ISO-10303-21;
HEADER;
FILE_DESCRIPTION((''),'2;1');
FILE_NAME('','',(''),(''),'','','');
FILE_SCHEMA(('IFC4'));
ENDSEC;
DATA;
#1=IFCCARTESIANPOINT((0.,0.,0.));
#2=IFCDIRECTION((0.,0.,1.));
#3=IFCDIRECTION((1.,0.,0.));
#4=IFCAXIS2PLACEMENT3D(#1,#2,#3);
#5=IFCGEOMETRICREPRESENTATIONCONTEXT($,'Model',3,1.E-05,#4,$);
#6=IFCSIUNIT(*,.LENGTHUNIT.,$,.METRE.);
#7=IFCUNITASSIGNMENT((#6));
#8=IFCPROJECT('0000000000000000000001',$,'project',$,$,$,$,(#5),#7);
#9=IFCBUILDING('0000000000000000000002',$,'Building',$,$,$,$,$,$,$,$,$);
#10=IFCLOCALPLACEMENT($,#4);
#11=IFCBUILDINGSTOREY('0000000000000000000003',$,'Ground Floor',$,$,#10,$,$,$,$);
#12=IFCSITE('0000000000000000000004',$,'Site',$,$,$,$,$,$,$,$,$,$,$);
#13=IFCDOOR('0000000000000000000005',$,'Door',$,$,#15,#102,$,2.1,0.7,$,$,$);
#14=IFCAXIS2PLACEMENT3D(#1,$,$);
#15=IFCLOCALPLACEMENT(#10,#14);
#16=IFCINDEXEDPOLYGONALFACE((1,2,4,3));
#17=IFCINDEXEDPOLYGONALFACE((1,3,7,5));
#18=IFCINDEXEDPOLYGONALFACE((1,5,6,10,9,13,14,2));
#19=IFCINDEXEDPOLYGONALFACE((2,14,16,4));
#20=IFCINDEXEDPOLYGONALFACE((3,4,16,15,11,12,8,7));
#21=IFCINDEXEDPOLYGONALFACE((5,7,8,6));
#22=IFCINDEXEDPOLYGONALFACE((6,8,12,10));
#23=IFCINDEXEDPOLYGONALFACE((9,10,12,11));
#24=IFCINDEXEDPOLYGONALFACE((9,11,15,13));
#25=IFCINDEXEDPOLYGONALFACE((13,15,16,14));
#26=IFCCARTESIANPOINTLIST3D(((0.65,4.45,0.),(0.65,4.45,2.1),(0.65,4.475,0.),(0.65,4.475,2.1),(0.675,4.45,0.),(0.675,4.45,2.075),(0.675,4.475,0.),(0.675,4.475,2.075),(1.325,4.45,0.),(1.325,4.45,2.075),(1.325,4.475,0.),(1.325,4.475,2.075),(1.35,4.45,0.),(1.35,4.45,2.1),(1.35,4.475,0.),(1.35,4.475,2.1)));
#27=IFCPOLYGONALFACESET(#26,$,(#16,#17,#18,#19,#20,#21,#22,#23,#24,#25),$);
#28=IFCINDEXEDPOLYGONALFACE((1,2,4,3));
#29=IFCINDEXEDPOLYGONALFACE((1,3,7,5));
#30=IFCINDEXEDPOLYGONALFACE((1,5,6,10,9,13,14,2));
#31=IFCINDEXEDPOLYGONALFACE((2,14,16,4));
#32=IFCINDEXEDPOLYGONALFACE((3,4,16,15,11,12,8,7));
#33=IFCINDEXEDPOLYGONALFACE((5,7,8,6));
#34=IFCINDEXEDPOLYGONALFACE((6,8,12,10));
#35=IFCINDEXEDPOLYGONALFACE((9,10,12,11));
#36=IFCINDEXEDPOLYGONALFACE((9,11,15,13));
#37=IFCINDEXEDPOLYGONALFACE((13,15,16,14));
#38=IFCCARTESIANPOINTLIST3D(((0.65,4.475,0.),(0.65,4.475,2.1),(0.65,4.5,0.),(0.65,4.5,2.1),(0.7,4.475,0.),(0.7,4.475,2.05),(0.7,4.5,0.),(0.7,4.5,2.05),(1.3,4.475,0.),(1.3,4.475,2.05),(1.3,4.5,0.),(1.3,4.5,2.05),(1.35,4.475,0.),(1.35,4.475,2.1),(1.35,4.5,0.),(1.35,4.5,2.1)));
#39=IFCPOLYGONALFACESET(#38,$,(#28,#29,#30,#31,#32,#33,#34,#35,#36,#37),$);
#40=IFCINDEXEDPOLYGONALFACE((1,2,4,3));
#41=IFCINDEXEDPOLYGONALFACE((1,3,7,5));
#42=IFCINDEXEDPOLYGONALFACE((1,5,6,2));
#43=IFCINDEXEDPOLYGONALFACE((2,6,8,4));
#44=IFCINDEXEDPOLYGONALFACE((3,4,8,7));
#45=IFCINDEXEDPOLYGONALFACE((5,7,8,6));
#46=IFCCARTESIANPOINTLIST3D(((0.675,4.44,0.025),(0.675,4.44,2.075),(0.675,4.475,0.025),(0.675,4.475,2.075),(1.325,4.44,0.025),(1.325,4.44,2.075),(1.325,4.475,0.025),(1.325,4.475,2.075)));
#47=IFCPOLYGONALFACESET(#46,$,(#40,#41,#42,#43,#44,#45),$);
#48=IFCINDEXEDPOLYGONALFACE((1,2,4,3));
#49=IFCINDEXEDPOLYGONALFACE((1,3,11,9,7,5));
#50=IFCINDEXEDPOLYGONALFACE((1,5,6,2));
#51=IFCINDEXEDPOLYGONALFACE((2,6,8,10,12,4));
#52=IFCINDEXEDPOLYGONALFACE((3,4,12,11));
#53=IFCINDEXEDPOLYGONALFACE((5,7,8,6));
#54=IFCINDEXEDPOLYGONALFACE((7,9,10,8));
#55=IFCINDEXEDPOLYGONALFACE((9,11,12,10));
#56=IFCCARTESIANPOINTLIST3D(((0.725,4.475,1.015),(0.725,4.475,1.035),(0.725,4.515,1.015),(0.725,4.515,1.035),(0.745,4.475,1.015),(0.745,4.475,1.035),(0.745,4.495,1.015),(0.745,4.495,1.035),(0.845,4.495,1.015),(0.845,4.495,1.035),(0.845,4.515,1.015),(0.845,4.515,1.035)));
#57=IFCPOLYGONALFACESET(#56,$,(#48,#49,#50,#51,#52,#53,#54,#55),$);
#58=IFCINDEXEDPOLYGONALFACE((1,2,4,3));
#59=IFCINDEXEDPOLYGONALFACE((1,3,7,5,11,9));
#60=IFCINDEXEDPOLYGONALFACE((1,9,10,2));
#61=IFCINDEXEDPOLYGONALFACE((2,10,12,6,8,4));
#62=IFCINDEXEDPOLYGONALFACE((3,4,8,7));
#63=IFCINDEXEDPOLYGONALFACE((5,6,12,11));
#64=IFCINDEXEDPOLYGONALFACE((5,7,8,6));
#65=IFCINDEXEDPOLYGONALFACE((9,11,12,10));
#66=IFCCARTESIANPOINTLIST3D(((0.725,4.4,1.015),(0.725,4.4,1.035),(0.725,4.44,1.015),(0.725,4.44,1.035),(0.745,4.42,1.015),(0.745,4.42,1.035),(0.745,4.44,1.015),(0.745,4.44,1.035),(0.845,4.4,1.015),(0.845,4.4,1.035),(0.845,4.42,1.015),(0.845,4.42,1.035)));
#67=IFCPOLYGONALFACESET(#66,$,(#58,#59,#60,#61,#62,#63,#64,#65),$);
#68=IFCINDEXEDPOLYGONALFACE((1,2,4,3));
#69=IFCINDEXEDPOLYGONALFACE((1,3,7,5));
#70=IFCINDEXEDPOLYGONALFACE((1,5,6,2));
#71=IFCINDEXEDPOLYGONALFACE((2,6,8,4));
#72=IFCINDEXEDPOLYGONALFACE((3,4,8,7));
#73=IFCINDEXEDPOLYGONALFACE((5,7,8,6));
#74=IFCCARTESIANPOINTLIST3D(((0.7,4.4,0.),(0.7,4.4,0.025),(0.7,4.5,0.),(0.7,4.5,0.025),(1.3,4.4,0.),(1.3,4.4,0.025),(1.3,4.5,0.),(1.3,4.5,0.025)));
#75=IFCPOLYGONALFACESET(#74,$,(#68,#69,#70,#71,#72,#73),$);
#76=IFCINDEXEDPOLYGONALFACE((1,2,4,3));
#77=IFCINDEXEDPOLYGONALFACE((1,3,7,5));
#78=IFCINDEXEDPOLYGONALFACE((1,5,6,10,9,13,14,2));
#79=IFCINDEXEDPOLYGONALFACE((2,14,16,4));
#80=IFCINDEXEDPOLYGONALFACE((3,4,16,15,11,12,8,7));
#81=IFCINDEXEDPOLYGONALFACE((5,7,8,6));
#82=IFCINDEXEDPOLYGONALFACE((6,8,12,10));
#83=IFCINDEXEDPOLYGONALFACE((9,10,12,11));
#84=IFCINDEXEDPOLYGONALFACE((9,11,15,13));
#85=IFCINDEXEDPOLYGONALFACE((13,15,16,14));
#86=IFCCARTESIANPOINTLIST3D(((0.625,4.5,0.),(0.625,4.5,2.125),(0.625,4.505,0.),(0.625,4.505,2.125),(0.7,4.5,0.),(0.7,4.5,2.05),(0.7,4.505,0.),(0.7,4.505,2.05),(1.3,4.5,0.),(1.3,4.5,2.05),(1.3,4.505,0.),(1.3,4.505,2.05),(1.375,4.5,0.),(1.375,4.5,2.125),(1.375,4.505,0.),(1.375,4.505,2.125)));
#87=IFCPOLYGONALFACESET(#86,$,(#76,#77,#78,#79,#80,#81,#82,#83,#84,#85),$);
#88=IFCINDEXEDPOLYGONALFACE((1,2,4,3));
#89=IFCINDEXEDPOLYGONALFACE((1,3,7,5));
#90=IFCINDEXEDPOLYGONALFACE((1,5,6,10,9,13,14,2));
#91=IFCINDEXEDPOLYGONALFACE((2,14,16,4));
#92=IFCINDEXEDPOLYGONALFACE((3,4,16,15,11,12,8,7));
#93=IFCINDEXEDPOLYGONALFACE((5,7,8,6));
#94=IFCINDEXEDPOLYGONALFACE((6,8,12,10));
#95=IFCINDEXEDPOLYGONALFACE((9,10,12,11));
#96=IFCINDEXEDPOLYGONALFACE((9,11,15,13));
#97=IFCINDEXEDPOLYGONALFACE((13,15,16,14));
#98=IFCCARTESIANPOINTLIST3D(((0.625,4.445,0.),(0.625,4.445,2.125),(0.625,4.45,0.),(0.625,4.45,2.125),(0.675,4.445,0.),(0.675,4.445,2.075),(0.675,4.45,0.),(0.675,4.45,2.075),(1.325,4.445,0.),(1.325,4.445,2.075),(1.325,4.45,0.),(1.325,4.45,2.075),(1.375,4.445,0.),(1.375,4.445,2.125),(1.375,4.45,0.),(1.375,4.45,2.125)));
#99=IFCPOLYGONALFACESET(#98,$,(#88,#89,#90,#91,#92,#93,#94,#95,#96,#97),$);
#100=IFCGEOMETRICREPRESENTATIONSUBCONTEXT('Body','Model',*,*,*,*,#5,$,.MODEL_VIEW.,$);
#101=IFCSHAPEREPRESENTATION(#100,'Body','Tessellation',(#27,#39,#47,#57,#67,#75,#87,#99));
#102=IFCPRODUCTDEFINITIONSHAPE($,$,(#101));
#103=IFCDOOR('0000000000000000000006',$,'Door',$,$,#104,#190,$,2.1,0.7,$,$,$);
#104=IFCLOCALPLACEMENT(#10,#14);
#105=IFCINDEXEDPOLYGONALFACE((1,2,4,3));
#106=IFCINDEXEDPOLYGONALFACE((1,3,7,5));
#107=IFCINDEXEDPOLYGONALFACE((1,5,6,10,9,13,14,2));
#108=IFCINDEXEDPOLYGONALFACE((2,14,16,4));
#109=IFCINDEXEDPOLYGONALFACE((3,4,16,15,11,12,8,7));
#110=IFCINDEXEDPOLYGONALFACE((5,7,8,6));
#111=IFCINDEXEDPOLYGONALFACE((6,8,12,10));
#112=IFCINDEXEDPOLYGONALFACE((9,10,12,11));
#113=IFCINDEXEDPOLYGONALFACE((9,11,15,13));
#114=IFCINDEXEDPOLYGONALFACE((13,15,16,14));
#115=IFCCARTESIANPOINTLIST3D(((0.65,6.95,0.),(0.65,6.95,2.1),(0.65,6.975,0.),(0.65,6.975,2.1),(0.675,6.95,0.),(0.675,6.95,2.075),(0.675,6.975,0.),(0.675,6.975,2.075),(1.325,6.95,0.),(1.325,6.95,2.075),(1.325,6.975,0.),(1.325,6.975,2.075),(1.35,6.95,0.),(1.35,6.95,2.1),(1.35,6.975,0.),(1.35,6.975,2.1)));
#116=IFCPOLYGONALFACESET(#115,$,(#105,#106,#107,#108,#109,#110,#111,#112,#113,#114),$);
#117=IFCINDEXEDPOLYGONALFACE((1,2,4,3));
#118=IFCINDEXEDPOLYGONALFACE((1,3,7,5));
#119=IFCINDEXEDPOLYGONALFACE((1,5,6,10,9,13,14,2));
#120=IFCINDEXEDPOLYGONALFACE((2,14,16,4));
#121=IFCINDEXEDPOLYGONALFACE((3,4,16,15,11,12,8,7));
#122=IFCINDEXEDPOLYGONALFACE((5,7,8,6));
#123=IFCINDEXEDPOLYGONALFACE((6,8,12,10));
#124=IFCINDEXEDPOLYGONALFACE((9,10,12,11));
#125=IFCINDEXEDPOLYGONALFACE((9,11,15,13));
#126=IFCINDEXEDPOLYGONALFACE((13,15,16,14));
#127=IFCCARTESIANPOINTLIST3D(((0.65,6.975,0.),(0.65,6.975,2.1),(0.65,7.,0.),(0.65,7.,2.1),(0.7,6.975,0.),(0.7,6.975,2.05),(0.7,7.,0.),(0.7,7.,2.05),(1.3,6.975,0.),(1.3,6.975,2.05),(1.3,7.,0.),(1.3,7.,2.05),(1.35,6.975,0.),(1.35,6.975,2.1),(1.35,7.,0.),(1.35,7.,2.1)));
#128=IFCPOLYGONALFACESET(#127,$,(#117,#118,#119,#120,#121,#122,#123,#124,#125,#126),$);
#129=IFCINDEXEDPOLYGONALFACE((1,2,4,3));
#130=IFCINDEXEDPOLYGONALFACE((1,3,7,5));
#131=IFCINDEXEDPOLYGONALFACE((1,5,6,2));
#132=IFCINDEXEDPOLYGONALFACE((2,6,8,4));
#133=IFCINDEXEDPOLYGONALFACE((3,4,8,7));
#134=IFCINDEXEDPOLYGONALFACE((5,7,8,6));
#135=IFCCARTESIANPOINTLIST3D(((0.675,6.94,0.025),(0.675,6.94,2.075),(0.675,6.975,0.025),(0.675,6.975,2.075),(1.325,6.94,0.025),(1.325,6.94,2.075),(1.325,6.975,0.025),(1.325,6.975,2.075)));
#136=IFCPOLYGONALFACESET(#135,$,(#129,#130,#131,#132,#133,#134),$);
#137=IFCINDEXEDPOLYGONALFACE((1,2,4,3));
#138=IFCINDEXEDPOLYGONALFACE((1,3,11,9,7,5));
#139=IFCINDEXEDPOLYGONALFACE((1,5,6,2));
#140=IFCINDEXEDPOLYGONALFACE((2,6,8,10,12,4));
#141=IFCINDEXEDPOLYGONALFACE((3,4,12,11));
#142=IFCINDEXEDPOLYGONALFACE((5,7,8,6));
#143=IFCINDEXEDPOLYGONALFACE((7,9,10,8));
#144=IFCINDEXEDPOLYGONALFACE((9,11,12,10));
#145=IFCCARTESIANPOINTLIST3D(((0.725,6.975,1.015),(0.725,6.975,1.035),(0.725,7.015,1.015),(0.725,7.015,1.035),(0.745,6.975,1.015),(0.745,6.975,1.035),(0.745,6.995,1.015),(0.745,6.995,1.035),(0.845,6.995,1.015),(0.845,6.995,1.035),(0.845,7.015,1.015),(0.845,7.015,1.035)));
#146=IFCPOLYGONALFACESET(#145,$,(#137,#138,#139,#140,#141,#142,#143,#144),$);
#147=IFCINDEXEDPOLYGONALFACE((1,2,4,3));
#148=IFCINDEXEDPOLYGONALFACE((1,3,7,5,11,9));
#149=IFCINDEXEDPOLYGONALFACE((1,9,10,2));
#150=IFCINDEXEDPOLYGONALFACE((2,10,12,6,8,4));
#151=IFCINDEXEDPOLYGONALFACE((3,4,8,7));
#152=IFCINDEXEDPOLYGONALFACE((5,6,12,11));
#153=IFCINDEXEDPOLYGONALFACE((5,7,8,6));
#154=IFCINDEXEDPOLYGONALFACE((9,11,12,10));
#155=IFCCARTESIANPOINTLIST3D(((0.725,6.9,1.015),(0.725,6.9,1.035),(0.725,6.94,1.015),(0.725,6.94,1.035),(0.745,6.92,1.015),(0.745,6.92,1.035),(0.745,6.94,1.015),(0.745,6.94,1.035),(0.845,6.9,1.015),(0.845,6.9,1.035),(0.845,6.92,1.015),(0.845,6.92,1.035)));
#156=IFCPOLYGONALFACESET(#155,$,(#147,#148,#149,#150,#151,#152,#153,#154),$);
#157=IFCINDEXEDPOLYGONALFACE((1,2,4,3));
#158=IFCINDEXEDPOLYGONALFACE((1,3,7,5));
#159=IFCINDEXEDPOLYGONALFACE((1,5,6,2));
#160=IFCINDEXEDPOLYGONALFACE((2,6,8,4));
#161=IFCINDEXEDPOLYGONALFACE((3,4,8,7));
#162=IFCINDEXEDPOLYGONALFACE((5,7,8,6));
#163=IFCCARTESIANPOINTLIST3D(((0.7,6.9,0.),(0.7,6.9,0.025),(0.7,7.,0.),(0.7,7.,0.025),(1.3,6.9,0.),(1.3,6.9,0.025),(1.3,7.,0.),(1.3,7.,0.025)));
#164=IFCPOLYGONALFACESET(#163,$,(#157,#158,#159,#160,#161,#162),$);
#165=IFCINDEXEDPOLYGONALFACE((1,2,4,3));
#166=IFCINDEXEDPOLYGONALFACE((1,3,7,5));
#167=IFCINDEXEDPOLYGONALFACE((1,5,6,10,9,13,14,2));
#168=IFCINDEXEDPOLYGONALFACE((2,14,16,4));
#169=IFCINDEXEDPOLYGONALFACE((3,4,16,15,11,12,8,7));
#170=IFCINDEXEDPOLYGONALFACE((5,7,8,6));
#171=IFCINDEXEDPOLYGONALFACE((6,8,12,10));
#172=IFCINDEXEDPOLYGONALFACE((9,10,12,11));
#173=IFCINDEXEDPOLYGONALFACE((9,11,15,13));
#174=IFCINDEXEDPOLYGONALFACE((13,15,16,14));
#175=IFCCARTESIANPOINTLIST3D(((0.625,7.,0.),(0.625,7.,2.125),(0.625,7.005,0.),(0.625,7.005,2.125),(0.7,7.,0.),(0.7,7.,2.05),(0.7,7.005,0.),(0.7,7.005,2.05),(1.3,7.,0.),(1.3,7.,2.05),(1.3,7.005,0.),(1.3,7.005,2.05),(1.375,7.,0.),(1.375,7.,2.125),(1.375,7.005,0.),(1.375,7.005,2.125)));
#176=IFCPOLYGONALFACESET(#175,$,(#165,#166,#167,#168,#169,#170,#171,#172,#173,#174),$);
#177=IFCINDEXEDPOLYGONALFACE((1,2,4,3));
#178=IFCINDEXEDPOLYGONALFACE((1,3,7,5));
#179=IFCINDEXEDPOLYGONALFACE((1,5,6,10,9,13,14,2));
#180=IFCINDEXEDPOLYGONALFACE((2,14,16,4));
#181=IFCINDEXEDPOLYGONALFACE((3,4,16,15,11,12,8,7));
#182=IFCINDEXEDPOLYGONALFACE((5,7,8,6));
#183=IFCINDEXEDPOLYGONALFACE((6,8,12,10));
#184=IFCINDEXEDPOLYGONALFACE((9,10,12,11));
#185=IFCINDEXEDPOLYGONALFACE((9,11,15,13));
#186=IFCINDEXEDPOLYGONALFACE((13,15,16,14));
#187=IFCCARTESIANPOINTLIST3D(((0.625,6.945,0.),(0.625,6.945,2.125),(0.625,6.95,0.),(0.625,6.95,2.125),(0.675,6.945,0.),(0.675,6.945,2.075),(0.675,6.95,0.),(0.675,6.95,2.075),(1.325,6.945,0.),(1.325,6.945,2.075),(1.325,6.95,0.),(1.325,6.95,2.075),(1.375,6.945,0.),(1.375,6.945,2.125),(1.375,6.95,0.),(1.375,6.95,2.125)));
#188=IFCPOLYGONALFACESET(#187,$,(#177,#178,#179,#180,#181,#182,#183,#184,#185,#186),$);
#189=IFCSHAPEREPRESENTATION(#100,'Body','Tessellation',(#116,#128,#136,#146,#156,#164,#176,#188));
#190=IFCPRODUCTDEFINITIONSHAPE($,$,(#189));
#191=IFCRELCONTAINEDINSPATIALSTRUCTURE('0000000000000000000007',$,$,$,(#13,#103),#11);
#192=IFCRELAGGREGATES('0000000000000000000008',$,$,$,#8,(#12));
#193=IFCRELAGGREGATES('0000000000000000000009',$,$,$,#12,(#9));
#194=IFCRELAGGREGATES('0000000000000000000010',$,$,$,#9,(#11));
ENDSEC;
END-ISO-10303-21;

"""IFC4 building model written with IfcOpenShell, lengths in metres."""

from ifc_helpers import new_model, si_unit, frame, origin_with_axes, place, context, subcontext, project, spatial, line, indexed_curve, outline, extrude, element, save


model = new_model("IFC4")

# Units and contexts
model_context = context("Model", 3, precision=1e-05, world=origin_with_axes())
body_context = subcontext(model_context, "Body", "Model", "MODEL_VIEW")
ifc_project = project(units=[si_unit("LENGTHUNIT", "METRE")], contexts=[model_context])

# Site, building, storey
site = spatial("IfcSite", under=ifc_project, Name="Site")
building = spatial("IfcBuilding", under=site, Name="Building")
storey_placement = place(None, origin_with_axes())
storey = spatial("IfcBuildingStorey", under=building, at=storey_placement, Name="Ground Floor")

# Doors
door_1_placement = place(storey_placement, frame((1.35, 4.5, 0.0), z_axis=(0.0, 0.0, 1.0), x_axis=(-1.0, 0.0, 0.0)))
element("IfcDoor", 1, at=door_1_placement, inside=storey, Name="Door", OverallHeight=2.1, OverallWidth=0.7, context=body_context, shape_type="SweptSolid", body=[
    extrude(outline(indexed_curve([(0.0, 0.0), (0.0, 2.1), (0.7, 2.1), (0.7, 0.0), (0.675, 0.0), (0.675, 2.075), (0.025, 2.075), (0.025, 0.0)], segments=[line(1, 2, 3, 4, 5, 6, 7, 8, 1)])), frame((0.0, 0.025, 0.0), z_axis=(0.0, -1.0, 0.0), x_axis=(1.0, 0.0, 0.0)), (0.0, 0.0, -1.0), 0.025),
    extrude(outline(indexed_curve([(0.0, 0.0), (0.0, 2.1), (0.7, 2.1), (0.7, 0.0), (0.65, 0.0), (0.65, 2.05), (0.05, 2.05), (0.05, 0.0)], segments=[line(1, 2, 3, 4, 5, 6, 7, 8, 1)])), frame((0.0, 0.0, 0.0), z_axis=(0.0, -1.0, 0.0), x_axis=(1.0, 0.0, 0.0)), (0.0, 0.0, -1.0), 0.025),
    extrude(outline(indexed_curve([(0.0, 0.0), (0.65, 0.0), (0.65, 0.035), (0.0, 0.035)], segments=[line(1, 2, 3, 4, 1)])), frame((0.025, 0.025, 0.025), z_axis=(0.0, 0.0, 1.0), x_axis=(1.0, 0.0, 0.0)), (0.0, 0.0, 1.0), 2.05),
    extrude(outline(indexed_curve([(0.0, 0.0), (0.0, -0.04), (-0.12, -0.04), (-0.12, -0.02), (-0.02, -0.02), (-0.02, 0.0)], segments=[line(1, 2, 3, 4, 5, 6, 1)])), frame((0.625, 0.025, 1.015), z_axis=(0.0, 0.0, 1.0), x_axis=(1.0, 0.0, 0.0)), (0.0, 0.0, 1.0), 0.02),
    extrude(outline(indexed_curve([(0.0, 0.0), (0.0, 0.04), (-0.12, 0.04), (-0.12, 0.02), (-0.02, 0.02), (-0.02, 0.0)], segments=[line(1, 2, 3, 4, 5, 6, 1)])), frame((0.625, 0.06, 1.015), z_axis=(0.0, 0.0, 1.0), x_axis=(1.0, 0.0, 0.0)), (0.0, 0.0, 1.0), 0.02),
    extrude(outline(indexed_curve([(0.0, 0.0), (0.6, 0.0), (0.6, 0.1), (0.0, 0.1)], segments=[line(1, 2, 3, 4, 1)])), frame((0.05, 0.0, 0.0), z_axis=(0.0, 0.0, 1.0), x_axis=(1.0, 0.0, 0.0)), (0.0, 0.0, 1.0), 0.025),
    extrude(outline(indexed_curve([(0.0, 0.0), (0.0, 2.125), (0.75, 2.125), (0.75, 0.0), (0.675, 0.0), (0.675, 2.05), (0.075, 2.05), (0.075, 0.0)], segments=[line(1, 2, 3, 4, 5, 6, 7, 8, 1)])), frame((-0.025, -0.005, 0.0), z_axis=(0.0, -1.0, 0.0), x_axis=(1.0, 0.0, 0.0)), (0.0, 0.0, -1.0), 0.005),
    extrude(outline(indexed_curve([(0.0, 0.0), (0.0, 2.125), (0.75, 2.125), (0.75, 0.0), (0.7, 0.0), (0.7, 2.075), (0.05, 2.075), (0.05, 0.0)], segments=[line(1, 2, 3, 4, 5, 6, 7, 8, 1)])), frame((-0.025, 0.05, 0.0), z_axis=(0.0, -1.0, 0.0), x_axis=(1.0, 0.0, 0.0)), (0.0, 0.0, -1.0), 0.005),
])
door_2_placement = place(storey_placement, frame((1.35, 7.0, 0.0), z_axis=(0.0, 0.0, 1.0), x_axis=(-1.0, 0.0, 0.0)))
element("IfcDoor", 2, at=door_2_placement, inside=storey, Name="Door", OverallHeight=2.1, OverallWidth=0.7, context=body_context, shape_type="SweptSolid", body=[
    extrude(outline(indexed_curve([(0.0, 0.0), (0.0, 2.1), (0.7, 2.1), (0.7, 0.0), (0.675, 0.0), (0.675, 2.075), (0.025, 2.075), (0.025, 0.0)], segments=[line(1, 2, 3, 4, 5, 6, 7, 8, 1)])), frame((0.0, 0.025, 0.0), z_axis=(0.0, -1.0, 0.0), x_axis=(1.0, 0.0, 0.0)), (0.0, 0.0, -1.0), 0.025),
    extrude(outline(indexed_curve([(0.0, 0.0), (0.0, 2.1), (0.7, 2.1), (0.7, 0.0), (0.65, 0.0), (0.65, 2.05), (0.05, 2.05), (0.05, 0.0)], segments=[line(1, 2, 3, 4, 5, 6, 7, 8, 1)])), frame((0.0, 0.0, 0.0), z_axis=(0.0, -1.0, 0.0), x_axis=(1.0, 0.0, 0.0)), (0.0, 0.0, -1.0), 0.025),
    extrude(outline(indexed_curve([(0.0, 0.0), (0.65, 0.0), (0.65, 0.035), (0.0, 0.035)], segments=[line(1, 2, 3, 4, 1)])), frame((0.025, 0.025, 0.025), z_axis=(0.0, 0.0, 1.0), x_axis=(1.0, 0.0, 0.0)), (0.0, 0.0, 1.0), 2.05),
    extrude(outline(indexed_curve([(0.0, 0.0), (0.0, -0.04), (-0.12, -0.04), (-0.12, -0.02), (-0.02, -0.02), (-0.02, 0.0)], segments=[line(1, 2, 3, 4, 5, 6, 1)])), frame((0.625, 0.025, 1.015), z_axis=(0.0, 0.0, 1.0), x_axis=(1.0, 0.0, 0.0)), (0.0, 0.0, 1.0), 0.02),
    extrude(outline(indexed_curve([(0.0, 0.0), (0.0, 0.04), (-0.12, 0.04), (-0.12, 0.02), (-0.02, 0.02), (-0.02, 0.0)], segments=[line(1, 2, 3, 4, 5, 6, 1)])), frame((0.625, 0.06, 1.015), z_axis=(0.0, 0.0, 1.0), x_axis=(1.0, 0.0, 0.0)), (0.0, 0.0, 1.0), 0.02),
    extrude(outline(indexed_curve([(0.0, 0.0), (0.6, 0.0), (0.6, 0.1), (0.0, 0.1)], segments=[line(1, 2, 3, 4, 1)])), frame((0.05, 0.0, 0.0), z_axis=(0.0, 0.0, 1.0), x_axis=(1.0, 0.0, 0.0)), (0.0, 0.0, 1.0), 0.025),
    extrude(outline(indexed_curve([(0.0, 0.0), (0.0, 2.125), (0.75, 2.125), (0.75, 0.0), (0.675, 0.0), (0.675, 2.05), (0.075, 2.05), (0.075, 0.0)], segments=[line(1, 2, 3, 4, 5, 6, 7, 8, 1)])), frame((-0.025, -0.005, 0.0), z_axis=(0.0, -1.0, 0.0), x_axis=(1.0, 0.0, 0.0)), (0.0, 0.0, -1.0), 0.005),
    extrude(outline(indexed_curve([(0.0, 0.0), (0.0, 2.125), (0.75, 2.125), (0.75, 0.0), (0.7, 0.0), (0.7, 2.075), (0.05, 2.075), (0.05, 0.0)], segments=[line(1, 2, 3, 4, 5, 6, 7, 8, 1)])), frame((-0.025, 0.05, 0.0), z_axis=(0.0, -1.0, 0.0), x_axis=(1.0, 0.0, 0.0)), (0.0, 0.0, -1.0), 0.005),
])

save(model, "model.ifc")
